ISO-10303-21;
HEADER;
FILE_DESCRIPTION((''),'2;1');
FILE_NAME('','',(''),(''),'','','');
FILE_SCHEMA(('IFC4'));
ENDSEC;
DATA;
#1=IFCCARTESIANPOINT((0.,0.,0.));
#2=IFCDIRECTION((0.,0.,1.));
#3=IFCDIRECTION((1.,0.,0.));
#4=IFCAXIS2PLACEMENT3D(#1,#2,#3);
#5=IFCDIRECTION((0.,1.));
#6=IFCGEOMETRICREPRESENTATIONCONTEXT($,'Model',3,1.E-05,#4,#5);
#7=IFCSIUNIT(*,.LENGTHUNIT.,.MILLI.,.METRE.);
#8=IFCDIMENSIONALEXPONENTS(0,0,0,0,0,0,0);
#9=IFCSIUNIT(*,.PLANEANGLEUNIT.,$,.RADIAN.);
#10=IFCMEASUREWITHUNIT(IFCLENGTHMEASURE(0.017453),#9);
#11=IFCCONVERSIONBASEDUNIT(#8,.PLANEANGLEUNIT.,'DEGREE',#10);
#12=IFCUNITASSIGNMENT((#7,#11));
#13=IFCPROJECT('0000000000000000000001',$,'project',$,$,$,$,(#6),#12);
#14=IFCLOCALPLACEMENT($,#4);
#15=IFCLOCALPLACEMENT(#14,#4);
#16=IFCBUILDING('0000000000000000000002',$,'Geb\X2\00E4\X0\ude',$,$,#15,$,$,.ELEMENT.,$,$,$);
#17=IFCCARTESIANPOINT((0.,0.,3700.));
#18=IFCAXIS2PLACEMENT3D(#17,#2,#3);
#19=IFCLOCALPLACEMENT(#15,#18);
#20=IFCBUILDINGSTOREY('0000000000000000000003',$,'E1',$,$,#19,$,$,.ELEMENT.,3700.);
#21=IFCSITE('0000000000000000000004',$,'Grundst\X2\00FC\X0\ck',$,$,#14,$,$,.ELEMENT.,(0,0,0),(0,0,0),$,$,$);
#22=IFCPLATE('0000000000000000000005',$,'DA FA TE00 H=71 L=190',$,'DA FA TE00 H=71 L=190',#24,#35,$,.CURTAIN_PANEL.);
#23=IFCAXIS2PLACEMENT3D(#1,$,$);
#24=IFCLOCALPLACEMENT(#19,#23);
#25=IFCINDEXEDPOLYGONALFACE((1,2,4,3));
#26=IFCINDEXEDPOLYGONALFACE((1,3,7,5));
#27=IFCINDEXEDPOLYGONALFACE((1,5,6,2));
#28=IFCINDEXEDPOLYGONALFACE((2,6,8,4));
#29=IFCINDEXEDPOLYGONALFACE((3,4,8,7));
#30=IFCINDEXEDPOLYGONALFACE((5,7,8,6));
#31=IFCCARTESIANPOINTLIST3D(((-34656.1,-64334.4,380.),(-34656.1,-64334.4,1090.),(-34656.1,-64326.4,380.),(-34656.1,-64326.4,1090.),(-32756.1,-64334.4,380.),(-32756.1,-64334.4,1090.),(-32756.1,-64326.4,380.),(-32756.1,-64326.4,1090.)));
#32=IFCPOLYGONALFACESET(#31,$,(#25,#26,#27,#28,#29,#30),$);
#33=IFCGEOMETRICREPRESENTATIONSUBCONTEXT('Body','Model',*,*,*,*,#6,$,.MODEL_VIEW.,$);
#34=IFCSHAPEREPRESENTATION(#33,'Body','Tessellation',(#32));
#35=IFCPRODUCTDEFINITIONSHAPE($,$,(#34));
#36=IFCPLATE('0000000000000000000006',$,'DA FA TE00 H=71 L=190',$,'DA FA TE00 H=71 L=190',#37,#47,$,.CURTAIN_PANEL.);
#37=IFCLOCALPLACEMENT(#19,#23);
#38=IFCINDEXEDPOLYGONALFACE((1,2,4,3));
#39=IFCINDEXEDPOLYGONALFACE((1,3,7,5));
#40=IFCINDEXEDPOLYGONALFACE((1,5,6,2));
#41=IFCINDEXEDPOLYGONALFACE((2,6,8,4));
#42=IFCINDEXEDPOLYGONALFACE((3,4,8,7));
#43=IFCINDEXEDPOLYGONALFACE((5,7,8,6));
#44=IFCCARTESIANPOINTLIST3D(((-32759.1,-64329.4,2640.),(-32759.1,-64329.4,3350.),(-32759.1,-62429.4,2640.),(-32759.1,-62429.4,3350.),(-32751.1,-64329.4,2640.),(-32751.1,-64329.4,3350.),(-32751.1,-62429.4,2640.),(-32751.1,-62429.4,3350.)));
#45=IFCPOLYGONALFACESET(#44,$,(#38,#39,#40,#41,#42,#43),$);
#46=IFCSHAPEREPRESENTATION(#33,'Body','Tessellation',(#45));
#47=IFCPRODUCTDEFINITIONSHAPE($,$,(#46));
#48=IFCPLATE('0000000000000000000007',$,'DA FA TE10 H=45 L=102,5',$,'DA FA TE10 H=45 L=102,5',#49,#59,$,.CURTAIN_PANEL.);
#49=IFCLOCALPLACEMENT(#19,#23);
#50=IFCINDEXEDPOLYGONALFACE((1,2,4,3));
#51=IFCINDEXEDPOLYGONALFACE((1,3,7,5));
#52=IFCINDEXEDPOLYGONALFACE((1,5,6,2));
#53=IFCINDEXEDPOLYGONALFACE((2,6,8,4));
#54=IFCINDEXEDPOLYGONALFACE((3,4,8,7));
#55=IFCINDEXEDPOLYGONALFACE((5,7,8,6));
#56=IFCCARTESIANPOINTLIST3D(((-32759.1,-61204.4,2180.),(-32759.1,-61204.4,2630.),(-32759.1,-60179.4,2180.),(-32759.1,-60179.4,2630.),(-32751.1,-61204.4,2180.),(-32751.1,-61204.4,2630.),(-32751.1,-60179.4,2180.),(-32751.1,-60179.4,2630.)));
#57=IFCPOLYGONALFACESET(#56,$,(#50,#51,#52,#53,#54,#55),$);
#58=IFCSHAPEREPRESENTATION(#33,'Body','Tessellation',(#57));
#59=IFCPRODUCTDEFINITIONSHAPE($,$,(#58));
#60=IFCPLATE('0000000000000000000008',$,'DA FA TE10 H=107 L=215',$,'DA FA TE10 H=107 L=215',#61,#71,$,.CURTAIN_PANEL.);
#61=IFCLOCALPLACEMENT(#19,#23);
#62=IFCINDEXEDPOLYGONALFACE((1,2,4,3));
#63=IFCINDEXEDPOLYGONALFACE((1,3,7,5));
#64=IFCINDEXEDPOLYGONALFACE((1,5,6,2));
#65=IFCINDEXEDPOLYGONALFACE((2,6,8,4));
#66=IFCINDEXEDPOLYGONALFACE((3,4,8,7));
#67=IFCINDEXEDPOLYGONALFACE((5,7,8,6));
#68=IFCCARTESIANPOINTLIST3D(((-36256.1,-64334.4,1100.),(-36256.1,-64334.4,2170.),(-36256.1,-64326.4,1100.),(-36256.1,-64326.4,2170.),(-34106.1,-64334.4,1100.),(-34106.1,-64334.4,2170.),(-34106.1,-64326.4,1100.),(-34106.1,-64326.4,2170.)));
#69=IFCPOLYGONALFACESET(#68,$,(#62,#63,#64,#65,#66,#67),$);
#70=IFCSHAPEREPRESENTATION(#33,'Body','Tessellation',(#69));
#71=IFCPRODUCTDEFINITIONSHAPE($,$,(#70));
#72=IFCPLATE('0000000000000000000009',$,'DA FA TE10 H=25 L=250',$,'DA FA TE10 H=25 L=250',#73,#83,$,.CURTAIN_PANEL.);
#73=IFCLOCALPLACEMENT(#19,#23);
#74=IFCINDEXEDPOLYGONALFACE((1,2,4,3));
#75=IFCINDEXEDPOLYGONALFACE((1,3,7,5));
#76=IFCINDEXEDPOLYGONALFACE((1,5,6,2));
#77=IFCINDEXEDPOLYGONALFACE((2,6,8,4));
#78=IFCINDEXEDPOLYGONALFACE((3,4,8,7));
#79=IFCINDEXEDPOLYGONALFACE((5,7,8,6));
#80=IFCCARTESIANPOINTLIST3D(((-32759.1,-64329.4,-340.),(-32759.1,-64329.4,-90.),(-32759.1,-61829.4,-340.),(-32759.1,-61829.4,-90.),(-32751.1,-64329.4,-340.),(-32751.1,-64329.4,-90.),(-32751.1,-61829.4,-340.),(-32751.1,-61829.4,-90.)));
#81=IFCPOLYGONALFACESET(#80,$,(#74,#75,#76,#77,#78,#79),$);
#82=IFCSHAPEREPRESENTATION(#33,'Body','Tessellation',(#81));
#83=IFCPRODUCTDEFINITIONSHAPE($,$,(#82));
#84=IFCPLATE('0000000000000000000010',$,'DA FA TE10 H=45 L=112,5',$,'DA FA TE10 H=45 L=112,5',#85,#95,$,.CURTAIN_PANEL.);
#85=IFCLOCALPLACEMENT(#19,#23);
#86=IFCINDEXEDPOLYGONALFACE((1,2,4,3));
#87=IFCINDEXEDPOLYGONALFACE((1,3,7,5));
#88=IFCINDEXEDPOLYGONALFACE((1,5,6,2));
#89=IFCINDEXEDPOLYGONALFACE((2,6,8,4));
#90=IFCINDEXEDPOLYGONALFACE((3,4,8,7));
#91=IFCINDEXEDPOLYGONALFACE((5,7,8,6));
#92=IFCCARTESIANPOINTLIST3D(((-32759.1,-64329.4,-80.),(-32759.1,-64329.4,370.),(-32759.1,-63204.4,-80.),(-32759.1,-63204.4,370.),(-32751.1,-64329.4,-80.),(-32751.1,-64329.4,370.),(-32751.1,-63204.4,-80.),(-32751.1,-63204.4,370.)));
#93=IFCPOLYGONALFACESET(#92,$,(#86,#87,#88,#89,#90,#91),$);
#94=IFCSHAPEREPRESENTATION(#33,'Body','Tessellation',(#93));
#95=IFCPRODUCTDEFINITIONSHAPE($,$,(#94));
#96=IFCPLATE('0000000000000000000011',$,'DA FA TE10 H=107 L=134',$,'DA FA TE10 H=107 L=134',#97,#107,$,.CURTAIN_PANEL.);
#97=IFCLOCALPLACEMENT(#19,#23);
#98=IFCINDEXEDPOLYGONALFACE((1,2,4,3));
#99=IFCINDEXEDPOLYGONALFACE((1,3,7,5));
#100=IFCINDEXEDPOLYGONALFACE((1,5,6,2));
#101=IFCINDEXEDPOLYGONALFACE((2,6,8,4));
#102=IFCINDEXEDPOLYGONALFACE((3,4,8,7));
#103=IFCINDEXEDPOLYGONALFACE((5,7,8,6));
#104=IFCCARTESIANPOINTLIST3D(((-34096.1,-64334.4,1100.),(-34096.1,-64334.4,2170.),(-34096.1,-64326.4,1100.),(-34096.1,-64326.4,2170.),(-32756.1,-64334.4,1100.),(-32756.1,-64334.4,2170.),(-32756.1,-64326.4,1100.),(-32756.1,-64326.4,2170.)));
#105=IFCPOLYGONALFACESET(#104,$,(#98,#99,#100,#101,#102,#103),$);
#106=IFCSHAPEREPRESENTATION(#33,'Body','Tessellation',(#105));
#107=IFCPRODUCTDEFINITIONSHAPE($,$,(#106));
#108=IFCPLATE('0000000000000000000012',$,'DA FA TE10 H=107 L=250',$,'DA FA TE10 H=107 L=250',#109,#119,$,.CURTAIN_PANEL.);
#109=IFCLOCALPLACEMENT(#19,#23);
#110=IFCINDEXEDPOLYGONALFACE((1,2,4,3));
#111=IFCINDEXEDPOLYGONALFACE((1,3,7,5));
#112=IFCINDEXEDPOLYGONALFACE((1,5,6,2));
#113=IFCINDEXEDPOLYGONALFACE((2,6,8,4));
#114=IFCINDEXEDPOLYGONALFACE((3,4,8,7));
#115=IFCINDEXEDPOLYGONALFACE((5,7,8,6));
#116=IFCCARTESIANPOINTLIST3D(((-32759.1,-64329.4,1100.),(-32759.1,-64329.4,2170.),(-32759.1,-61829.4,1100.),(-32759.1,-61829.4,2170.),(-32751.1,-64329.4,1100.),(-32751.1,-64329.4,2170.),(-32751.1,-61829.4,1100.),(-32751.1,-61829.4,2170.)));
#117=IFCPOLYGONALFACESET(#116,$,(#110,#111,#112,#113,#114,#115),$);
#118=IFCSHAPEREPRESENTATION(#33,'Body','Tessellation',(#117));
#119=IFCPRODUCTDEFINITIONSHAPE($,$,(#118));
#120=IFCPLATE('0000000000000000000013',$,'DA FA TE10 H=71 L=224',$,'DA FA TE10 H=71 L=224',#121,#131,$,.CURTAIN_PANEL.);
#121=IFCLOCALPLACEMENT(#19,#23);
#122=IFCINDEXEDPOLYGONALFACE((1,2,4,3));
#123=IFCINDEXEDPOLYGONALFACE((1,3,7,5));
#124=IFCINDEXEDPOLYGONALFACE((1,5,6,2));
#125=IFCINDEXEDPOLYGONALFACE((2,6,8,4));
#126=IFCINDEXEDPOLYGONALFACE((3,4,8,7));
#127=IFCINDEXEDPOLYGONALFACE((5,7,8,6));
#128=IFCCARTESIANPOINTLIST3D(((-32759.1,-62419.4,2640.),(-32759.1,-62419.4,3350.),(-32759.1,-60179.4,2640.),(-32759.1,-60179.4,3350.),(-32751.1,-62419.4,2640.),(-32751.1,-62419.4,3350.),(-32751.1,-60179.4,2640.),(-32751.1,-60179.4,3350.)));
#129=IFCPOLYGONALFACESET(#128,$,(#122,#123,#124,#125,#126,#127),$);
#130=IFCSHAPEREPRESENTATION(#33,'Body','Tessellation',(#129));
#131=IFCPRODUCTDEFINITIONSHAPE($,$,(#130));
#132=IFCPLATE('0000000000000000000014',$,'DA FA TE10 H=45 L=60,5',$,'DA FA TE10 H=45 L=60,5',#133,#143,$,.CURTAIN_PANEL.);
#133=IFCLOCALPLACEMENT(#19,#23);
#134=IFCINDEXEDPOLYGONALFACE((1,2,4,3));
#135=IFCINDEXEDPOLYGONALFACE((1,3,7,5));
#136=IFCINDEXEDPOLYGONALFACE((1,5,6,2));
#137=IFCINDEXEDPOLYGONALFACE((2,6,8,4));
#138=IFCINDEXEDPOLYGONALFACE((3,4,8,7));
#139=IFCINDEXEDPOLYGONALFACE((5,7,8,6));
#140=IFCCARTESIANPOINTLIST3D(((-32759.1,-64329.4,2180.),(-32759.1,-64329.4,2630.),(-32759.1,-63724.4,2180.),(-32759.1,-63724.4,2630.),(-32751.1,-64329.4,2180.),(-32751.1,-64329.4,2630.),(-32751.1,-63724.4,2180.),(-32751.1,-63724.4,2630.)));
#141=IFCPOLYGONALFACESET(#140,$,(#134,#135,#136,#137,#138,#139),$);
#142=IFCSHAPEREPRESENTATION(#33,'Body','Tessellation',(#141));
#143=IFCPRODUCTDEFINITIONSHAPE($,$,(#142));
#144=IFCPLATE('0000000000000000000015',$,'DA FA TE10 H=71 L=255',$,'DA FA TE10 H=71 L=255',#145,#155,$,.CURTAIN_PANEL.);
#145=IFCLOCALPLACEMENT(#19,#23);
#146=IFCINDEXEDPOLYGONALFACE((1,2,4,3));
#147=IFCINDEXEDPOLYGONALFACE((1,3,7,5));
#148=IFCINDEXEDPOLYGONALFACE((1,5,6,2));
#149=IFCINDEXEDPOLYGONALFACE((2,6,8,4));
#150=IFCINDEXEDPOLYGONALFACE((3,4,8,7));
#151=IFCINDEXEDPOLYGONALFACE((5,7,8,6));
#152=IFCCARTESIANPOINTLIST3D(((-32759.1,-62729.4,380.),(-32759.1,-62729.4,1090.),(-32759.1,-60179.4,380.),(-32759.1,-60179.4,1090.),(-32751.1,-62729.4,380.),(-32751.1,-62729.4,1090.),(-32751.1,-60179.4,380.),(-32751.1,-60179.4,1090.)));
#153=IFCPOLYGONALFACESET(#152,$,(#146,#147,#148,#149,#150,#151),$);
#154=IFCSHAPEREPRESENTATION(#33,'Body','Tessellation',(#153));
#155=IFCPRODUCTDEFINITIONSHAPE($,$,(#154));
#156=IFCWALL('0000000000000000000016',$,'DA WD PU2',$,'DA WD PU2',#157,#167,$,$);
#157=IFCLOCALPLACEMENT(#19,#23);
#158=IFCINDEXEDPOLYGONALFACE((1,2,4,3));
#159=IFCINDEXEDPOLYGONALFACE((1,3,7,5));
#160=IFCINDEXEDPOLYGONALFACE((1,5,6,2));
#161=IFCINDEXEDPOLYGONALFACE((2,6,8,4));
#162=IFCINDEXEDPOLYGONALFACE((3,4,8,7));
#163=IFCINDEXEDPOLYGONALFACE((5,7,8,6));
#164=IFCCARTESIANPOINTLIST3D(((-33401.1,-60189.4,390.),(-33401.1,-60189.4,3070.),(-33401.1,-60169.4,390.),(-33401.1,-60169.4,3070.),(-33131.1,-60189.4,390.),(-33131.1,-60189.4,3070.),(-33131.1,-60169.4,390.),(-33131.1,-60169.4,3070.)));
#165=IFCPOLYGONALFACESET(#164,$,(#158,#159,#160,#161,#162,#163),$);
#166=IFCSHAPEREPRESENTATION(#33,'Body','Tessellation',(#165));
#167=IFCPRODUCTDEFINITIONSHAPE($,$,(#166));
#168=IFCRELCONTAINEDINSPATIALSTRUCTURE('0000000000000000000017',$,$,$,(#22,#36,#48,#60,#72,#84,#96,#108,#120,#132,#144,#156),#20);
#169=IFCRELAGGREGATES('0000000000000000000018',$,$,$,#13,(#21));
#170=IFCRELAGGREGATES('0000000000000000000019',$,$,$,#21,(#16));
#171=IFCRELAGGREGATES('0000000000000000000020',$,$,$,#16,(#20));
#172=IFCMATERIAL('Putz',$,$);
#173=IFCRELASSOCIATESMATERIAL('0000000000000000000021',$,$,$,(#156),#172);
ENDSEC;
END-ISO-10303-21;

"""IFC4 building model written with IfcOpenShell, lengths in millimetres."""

from ifc_helpers import new_model, entity, si_unit, converted_unit, direction, frame, origin_with_axes, place, context, subcontext, project, spatial, line, indexed_curve, outline, extrude, source, transform, mapped, material, element, save


model = new_model("IFC4")

# Units and contexts
model_context = context("Model", 3, precision=1e-05, world=origin_with_axes(), true_north=direction((0.0, 1.0)))
body_context = subcontext(model_context, "Body", "Model", "MODEL_VIEW")
ifc_project = project(units=[si_unit("LENGTHUNIT", "METRE", prefix="MILLI"), converted_unit("PLANEANGLEUNIT", "DEGREE", entity("IfcLengthMeasure", 0.017453), si_unit("PLANEANGLEUNIT", "RADIAN"), dimensions=[0, 0, 0, 0, 0, 0, 0])], contexts=[model_context])

# Site, building, storey
site_placement = place(None, origin_with_axes())
site = spatial("IfcSite", under=ifc_project, at=site_placement, Name="Grundstück", CompositionType="ELEMENT", RefLatitude=(0, 0, 0), RefLongitude=(0, 0, 0))
building_placement = place(site_placement, origin_with_axes())
building = spatial("IfcBuilding", under=site, at=building_placement, Name="Gebäude", CompositionType="ELEMENT")
storey_placement = place(building_placement, frame((0.0, 0.0, 3700.0), z_axis=(0.0, 0.0, 1.0), x_axis=(1.0, 0.0, 0.0)))
storey = spatial("IfcBuildingStorey", under=building, at=storey_placement, Name="E1", CompositionType="ELEMENT", Elevation=3700.0)

# Plates
shared_shape_1 = source(origin_with_axes(), body_context, "Body", "SweptSolid", [
    extrude(outline(indexed_curve([(-950.0, 0.0), (950.0, 0.0), (950.0, 8.0), (-950.0, 8.0)], segments=[line(1, 2), line(2, 3), line(3, 4), line(4, 1)])), frame((0.0, 0.0, 710.0), z_axis=(0.0, 0.0, 1.0), x_axis=(1.0, 0.0, 0.0)), (0.0, 0.0, -1.0), 710.0),
])
for number, where, z_axis, x_axis, name in (
    (1, (-33706.1, -64334.4, 380.0), (0.0, 0.0, 1.0), (1.0, 0.0, 0.0), "DA FA TE00 H=71 L=190"),
    (2, (-32751.1, -63379.4, 2640.0), (0.0, 0.0, 1.0), (0.0, 1.0, 0.0), "DA FA TE00 H=71 L=190"),
):
    element("IfcPlate", number, at=place(storey_placement, frame(where, z_axis=z_axis, x_axis=x_axis)), inside=storey, Name=name, ObjectType="DA FA TE00 H=71 L=190", PredefinedType="CURTAIN_PANEL", context=body_context, shape_type="MappedRepresentation", body=[
        mapped(shared_shape_1, transform((0.0, 0.0, 0.0), x_axis=(1.0, 0.0, 0.0), y_axis=(0.0, 1.0, 0.0), z_axis=(0.0, 0.0, 1.0), scale=1.0)),
    ])
shared_shape_2 = source(origin_with_axes(), body_context, "Body", "SweptSolid", [
    extrude(outline(indexed_curve([(-512.5, 0.0), (512.5, 0.0), (512.5, 8.0), (-512.5, 8.0)], segments=[line(1, 2), line(2, 3), line(3, 4), line(4, 1)])), frame((0.0, 0.0, 450.0), z_axis=(0.0, 0.0, 1.0), x_axis=(1.0, 0.0, 0.0)), (0.0, 0.0, -1.0), 450.0),
])
plate_1_placement = place(storey_placement, frame((-32751.1, -60691.9, 2180.0), z_axis=(0.0, 0.0, 1.0), x_axis=(0.0, 1.0, 0.0)))
element("IfcPlate", 3, at=plate_1_placement, inside=storey, Name="DA FA TE10 H=45 L=102,5", ObjectType="DA FA TE10 H=45 L=102,5", PredefinedType="CURTAIN_PANEL", context=body_context, shape_type="MappedRepresentation", body=[
    mapped(shared_shape_2, transform((0.0, 0.0, 0.0), x_axis=(1.0, 0.0, 0.0), y_axis=(0.0, 1.0, 0.0), z_axis=(0.0, 0.0, 1.0), scale=1.0)),
])
shared_shape_3 = source(origin_with_axes(), body_context, "Body", "SweptSolid", [
    extrude(outline(indexed_curve([(-1075.0, 0.0), (1075.0, 0.0), (1075.0, 8.0), (-1075.0, 8.0)], segments=[line(1, 2), line(2, 3), line(3, 4), line(4, 1)])), frame((0.0, 0.0, 1070.0), z_axis=(0.0, 0.0, 1.0), x_axis=(1.0, 0.0, 0.0)), (0.0, 0.0, -1.0), 1070.0),
])
plate_2_placement = place(storey_placement, frame((-35181.1, -64334.4, 1100.0), z_axis=(0.0, 0.0, 1.0), x_axis=(1.0, 0.0, 0.0)))
element("IfcPlate", 4, at=plate_2_placement, inside=storey, Name="DA FA TE10 H=107 L=215", ObjectType="DA FA TE10 H=107 L=215", PredefinedType="CURTAIN_PANEL", context=body_context, shape_type="MappedRepresentation", body=[
    mapped(shared_shape_3, transform((0.0, 0.0, 0.0), x_axis=(1.0, 0.0, 0.0), y_axis=(0.0, 1.0, 0.0), z_axis=(0.0, 0.0, 1.0), scale=1.0)),
])
plate_3_placement = place(storey_placement, frame((-32751.1, -63079.4, -340.0), z_axis=(0.0, 0.0, 1.0), x_axis=(0.0, 1.0, 0.0)))
element("IfcPlate", 5, at=plate_3_placement, inside=storey, Name="DA FA TE10 H=25 L=250", ObjectType="DA FA TE10 H=25 L=250", PredefinedType="CURTAIN_PANEL", context=body_context, shape_type="SweptSolid", body=[
    extrude(outline(indexed_curve([(-1250.0, 0.0), (1250.0, 0.0), (1250.0, 8.0), (-1250.0, 8.0)], segments=[line(1, 2), line(2, 3), line(3, 4), line(4, 1)])), frame((0.0, 0.0, 250.0), z_axis=(0.0, 0.0, 1.0), x_axis=(1.0, 0.0, 0.0)), (0.0, 0.0, -1.0), 250.0),
])
plate_4_placement = place(storey_placement, frame((-32751.1, -63766.9, -80.0), z_axis=(0.0, 0.0, 1.0), x_axis=(0.0, 1.0, 0.0)))
element("IfcPlate", 6, at=plate_4_placement, inside=storey, Name="DA FA TE10 H=45 L=112,5", ObjectType="DA FA TE10 H=45 L=112,5", PredefinedType="CURTAIN_PANEL", context=body_context, shape_type="SweptSolid", body=[
    extrude(outline(indexed_curve([(-562.5, 0.0), (562.5, 0.0), (562.5, 8.0), (-562.5, 8.0)], segments=[line(1, 2), line(2, 3), line(3, 4), line(4, 1)])), frame((0.0, 0.0, 450.0), z_axis=(0.0, 0.0, 1.0), x_axis=(1.0, 0.0, 0.0)), (0.0, 0.0, -1.0), 450.0),
])
plate_5_placement = place(storey_placement, frame((-33426.1, -64334.4, 1100.0), z_axis=(0.0, 0.0, 1.0), x_axis=(1.0, 0.0, 0.0)))
element("IfcPlate", 7, at=plate_5_placement, inside=storey, Name="DA FA TE10 H=107 L=134", ObjectType="DA FA TE10 H=107 L=134", PredefinedType="CURTAIN_PANEL", context=body_context, shape_type="SweptSolid", body=[
    extrude(outline(indexed_curve([(-670.0, 0.0), (670.0, 0.0), (670.0, 8.0), (-670.0, 8.0)], segments=[line(1, 2), line(2, 3), line(3, 4), line(4, 1)])), frame((0.0, 0.0, 1070.0), z_axis=(0.0, 0.0, 1.0), x_axis=(1.0, 0.0, 0.0)), (0.0, 0.0, -1.0), 1070.0),
])
plate_6_placement = place(storey_placement, frame((-32751.1, -63079.4, 1100.0), z_axis=(0.0, 0.0, 1.0), x_axis=(0.0, 1.0, 0.0)))
element("IfcPlate", 8, at=plate_6_placement, inside=storey, Name="DA FA TE10 H=107 L=250", ObjectType="DA FA TE10 H=107 L=250", PredefinedType="CURTAIN_PANEL", context=body_context, shape_type="SweptSolid", body=[
    extrude(outline(indexed_curve([(-1250.0, 0.0), (1250.0, 0.0), (1250.0, 8.0), (-1250.0, 8.0)], segments=[line(1, 2), line(2, 3), line(3, 4), line(4, 1)])), frame((0.0, 0.0, 1070.0), z_axis=(0.0, 0.0, 1.0), x_axis=(1.0, 0.0, 0.0)), (0.0, 0.0, -1.0), 1070.0),
])
plate_7_placement = place(storey_placement, frame((-32751.1, -61299.4, 2640.0), z_axis=(0.0, 0.0, 1.0), x_axis=(0.0, 1.0, 0.0)))
element("IfcPlate", 9, at=plate_7_placement, inside=storey, Name="DA FA TE10 H=71 L=224", ObjectType="DA FA TE10 H=71 L=224", PredefinedType="CURTAIN_PANEL", context=body_context, shape_type="SweptSolid", body=[
    extrude(outline(indexed_curve([(-1120.0, 0.0), (1120.0, 0.0), (1120.0, 8.0), (-1120.0, 8.0)], segments=[line(1, 2), line(2, 3), line(3, 4), line(4, 1)])), frame((0.0, 0.0, 710.0), z_axis=(0.0, 0.0, 1.0), x_axis=(1.0, 0.0, 0.0)), (0.0, 0.0, -1.0), 710.0),
])
plate_8_placement = place(storey_placement, frame((-32751.1, -64026.9, 2180.0), z_axis=(0.0, 0.0, 1.0), x_axis=(0.0, 1.0, 0.0)))
element("IfcPlate", 10, at=plate_8_placement, inside=storey, Name="DA FA TE10 H=45 L=60,5", ObjectType="DA FA TE10 H=45 L=60,5", PredefinedType="CURTAIN_PANEL", context=body_context, shape_type="SweptSolid", body=[
    extrude(outline(indexed_curve([(-302.5, 0.0), (302.5, 0.0), (302.5, 8.0), (-302.5, 8.0)], segments=[line(1, 2), line(2, 3), line(3, 4), line(4, 1)])), frame((0.0, 0.0, 450.0), z_axis=(0.0, 0.0, 1.0), x_axis=(1.0, 0.0, 0.0)), (0.0, 0.0, -1.0), 450.0),
])
plate_9_placement = place(storey_placement, frame((-32751.1, -61454.4, 380.0), z_axis=(0.0, 0.0, 1.0), x_axis=(0.0, 1.0, 0.0)))
element("IfcPlate", 11, at=plate_9_placement, inside=storey, Name="DA FA TE10 H=71 L=255", ObjectType="DA FA TE10 H=71 L=255", PredefinedType="CURTAIN_PANEL", context=body_context, shape_type="SweptSolid", body=[
    extrude(outline(indexed_curve([(-1275.0, 0.0), (1275.0, 0.0), (1275.0, 8.0), (-1275.0, 8.0)], segments=[line(1, 2), line(2, 3), line(3, 4), line(4, 1)])), frame((0.0, 0.0, 710.0), z_axis=(0.0, 0.0, 1.0), x_axis=(1.0, 0.0, 0.0)), (0.0, 0.0, -1.0), 710.0),
])

# Wall
ifc_material = material(Name="Putz")
wall_placement = place(storey_placement, frame((-33401.1, -60179.4, 390.0), z_axis=(0.0, 0.0, 1.0), x_axis=(1.0, 0.0, 0.0)))
element("IfcWall", 12, at=wall_placement, inside=storey, material=ifc_material, Name="DA WD PU2", ObjectType="DA WD PU2", context=body_context, shape_type="SweptSolid", body=[
    extrude(outline(indexed_curve([(0.0, -10.0), (0.0, 10.0), (270.0, 10.0), (270.0, -10.0)], segments=[line(1, 2), line(2, 3), line(3, 4), line(4, 1)])), origin_with_axes(), (0.0, 0.0, 1.0), 2680.0),
])

save(model, "model.ifc")
